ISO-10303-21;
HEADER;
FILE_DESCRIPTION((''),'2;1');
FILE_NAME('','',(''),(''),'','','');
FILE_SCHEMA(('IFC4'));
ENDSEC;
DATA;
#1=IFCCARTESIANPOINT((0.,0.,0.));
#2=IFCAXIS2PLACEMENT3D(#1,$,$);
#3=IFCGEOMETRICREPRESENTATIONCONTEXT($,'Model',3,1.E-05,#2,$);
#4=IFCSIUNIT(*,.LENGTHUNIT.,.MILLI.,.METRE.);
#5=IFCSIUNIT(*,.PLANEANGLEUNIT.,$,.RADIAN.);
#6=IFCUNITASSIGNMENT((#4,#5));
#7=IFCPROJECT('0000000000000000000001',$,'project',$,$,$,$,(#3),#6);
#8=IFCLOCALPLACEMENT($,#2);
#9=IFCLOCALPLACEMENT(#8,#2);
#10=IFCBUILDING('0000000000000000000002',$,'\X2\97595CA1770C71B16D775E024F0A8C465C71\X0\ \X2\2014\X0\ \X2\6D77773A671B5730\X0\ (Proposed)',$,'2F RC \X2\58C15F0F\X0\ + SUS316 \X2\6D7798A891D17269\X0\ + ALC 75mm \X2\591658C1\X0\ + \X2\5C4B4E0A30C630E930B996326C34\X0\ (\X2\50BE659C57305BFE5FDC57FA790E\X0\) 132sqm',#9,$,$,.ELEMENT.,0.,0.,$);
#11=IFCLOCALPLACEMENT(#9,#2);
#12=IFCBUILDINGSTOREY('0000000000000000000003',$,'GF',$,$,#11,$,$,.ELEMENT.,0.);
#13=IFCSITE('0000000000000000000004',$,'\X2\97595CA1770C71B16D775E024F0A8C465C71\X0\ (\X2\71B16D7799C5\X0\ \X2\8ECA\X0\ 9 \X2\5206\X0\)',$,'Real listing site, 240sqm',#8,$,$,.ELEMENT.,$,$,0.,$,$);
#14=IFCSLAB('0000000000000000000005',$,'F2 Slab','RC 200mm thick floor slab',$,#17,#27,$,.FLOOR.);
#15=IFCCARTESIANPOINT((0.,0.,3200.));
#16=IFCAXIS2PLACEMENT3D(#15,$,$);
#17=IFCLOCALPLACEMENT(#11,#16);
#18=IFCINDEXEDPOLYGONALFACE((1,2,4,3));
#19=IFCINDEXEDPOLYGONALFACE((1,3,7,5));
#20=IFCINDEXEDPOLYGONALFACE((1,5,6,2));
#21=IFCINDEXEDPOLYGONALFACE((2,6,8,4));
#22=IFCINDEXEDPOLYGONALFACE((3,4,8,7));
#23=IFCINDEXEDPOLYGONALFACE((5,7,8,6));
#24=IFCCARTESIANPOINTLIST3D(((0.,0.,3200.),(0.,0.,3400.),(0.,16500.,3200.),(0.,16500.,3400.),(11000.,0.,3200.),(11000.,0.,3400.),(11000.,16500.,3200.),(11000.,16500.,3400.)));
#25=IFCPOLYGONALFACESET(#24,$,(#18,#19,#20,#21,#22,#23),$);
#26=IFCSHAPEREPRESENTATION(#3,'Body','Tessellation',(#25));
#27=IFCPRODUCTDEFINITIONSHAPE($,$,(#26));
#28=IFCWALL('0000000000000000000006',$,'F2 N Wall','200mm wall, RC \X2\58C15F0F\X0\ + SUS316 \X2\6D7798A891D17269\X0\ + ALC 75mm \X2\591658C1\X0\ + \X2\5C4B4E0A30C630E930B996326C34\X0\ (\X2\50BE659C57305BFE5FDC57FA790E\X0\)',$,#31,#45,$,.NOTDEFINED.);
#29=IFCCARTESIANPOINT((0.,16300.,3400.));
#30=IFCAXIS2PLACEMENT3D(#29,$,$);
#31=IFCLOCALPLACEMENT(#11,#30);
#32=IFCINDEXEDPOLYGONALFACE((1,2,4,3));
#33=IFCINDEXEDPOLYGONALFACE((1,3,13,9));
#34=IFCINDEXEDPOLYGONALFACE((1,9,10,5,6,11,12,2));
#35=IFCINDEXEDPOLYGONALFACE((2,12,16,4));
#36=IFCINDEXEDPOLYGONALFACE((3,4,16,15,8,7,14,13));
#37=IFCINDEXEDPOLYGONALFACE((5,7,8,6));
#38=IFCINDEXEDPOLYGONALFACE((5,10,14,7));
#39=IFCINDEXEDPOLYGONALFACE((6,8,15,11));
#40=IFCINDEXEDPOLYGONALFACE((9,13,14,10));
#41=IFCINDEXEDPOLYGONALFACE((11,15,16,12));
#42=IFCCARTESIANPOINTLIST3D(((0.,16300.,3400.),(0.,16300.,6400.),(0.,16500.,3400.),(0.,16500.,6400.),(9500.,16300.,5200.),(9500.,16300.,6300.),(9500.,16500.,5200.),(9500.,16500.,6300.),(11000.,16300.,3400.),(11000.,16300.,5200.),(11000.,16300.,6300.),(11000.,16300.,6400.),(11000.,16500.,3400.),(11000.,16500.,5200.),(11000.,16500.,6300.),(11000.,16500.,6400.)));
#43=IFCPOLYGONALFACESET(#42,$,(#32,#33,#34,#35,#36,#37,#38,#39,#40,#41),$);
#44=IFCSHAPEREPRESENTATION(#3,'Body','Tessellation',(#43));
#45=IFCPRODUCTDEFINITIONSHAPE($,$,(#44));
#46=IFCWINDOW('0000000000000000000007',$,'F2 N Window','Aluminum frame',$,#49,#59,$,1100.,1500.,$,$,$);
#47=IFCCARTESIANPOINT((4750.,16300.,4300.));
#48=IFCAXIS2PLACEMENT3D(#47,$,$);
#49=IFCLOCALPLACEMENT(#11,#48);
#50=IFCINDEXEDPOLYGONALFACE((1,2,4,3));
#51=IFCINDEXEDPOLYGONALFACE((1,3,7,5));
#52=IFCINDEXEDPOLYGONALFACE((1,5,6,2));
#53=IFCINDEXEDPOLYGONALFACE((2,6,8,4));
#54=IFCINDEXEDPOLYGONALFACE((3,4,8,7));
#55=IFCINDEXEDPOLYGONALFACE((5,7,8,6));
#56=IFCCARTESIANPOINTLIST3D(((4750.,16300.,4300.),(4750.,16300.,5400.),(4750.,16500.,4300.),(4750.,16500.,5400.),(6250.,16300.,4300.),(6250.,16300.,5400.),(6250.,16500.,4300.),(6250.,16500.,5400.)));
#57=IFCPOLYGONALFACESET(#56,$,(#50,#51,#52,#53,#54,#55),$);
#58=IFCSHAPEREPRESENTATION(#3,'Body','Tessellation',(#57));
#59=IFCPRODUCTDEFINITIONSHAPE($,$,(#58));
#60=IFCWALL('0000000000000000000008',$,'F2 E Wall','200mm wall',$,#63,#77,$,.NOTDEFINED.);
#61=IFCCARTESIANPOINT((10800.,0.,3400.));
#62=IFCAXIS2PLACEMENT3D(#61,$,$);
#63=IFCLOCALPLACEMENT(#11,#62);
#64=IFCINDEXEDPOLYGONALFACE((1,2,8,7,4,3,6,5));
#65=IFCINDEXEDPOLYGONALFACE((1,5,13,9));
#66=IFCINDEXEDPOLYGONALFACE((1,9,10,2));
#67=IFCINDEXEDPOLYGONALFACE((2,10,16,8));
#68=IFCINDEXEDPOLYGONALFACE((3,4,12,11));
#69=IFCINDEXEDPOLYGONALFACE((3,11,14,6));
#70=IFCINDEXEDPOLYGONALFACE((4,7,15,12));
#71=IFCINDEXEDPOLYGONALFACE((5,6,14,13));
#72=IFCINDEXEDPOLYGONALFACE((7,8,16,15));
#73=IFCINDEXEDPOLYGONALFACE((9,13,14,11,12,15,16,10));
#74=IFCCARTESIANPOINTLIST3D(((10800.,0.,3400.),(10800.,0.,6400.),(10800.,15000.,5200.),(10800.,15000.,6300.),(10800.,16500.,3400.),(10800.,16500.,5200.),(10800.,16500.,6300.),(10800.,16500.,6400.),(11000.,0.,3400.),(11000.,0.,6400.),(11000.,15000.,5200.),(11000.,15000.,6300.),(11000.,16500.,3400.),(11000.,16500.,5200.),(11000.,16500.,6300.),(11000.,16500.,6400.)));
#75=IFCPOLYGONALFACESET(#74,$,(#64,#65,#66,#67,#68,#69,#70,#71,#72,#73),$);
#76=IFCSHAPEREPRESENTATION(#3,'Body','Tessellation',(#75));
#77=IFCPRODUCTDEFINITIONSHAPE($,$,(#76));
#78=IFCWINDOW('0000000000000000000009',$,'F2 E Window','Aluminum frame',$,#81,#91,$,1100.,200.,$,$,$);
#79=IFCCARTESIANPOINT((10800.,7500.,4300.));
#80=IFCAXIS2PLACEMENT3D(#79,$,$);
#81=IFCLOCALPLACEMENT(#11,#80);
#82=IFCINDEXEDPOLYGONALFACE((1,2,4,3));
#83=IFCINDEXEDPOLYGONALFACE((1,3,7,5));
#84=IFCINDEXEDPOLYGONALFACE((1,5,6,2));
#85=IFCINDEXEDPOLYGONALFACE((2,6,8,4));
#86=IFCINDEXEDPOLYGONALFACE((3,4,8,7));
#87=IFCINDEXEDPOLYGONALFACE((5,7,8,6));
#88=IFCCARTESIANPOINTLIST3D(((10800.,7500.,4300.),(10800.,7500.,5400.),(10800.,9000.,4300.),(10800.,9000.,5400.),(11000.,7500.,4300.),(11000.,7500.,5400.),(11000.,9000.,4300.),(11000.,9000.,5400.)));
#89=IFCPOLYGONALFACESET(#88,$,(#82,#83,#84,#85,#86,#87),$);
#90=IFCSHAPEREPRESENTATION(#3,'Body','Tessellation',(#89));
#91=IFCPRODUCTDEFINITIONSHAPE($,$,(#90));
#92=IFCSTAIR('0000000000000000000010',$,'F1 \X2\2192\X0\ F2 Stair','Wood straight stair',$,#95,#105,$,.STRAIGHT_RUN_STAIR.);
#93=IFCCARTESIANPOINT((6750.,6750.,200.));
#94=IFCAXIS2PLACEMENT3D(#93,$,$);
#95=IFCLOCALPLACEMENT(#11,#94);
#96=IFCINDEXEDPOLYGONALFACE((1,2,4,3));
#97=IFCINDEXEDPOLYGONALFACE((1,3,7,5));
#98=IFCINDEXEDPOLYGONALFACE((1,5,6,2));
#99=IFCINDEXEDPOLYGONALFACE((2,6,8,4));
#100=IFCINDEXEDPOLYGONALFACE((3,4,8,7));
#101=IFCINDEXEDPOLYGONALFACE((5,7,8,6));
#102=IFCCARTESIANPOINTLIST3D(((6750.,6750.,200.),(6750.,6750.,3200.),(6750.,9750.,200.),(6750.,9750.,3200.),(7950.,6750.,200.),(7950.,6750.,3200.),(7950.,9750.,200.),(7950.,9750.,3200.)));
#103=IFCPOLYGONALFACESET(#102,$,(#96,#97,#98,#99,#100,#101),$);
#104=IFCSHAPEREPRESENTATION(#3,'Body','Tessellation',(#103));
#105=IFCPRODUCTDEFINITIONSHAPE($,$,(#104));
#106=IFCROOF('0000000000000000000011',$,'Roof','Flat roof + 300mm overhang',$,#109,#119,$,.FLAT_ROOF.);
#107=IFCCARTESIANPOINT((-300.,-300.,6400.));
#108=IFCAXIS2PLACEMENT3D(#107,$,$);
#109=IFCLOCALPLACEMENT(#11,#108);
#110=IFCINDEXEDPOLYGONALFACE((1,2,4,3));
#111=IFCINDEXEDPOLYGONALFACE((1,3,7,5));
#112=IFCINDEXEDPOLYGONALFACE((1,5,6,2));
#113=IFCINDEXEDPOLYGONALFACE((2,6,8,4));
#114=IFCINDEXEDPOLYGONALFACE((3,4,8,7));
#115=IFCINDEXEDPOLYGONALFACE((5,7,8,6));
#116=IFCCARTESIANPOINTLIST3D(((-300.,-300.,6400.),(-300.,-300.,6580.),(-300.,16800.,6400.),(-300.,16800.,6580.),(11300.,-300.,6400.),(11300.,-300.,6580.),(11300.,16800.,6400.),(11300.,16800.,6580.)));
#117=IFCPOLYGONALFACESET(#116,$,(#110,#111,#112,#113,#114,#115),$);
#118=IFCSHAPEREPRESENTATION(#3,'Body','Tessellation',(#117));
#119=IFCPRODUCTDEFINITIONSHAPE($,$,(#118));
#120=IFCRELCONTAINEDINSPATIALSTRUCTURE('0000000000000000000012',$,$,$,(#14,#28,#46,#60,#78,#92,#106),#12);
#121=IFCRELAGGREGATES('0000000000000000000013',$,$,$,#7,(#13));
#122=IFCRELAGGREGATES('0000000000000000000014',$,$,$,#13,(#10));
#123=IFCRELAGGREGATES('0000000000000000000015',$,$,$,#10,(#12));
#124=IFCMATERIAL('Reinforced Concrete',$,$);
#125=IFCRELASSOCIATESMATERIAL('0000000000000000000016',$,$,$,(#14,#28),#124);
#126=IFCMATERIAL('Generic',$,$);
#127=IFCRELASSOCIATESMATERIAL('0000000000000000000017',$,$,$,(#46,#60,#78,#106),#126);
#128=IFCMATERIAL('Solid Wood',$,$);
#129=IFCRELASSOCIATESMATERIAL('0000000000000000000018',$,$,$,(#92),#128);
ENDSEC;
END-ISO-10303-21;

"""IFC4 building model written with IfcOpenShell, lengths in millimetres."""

from ifc_helpers import new_model, si_unit, frame, frame_2d, origin, place, context, project, spatial, rectangle, extrude, material, element, fill, save


model = new_model("IFC4")

# Units and contexts
model_context = context("Model", 3, precision=1e-05, world=origin())
ifc_project = project(units=[si_unit("LENGTHUNIT", "METRE", prefix="MILLI"), si_unit("PLANEANGLEUNIT", "RADIAN")], contexts=[model_context])

# Site, building, storey
site_placement = place(None, origin())
site = spatial("IfcSite", under=ifc_project, at=site_placement, Name="静岡県熱海市伊豆山 (熱海駅 車 9 分)", ObjectType="Real listing site, 240sqm", CompositionType="ELEMENT", RefElevation=0.0)
building_placement = place(site_placement, origin())
building = spatial("IfcBuilding", under=site, at=building_placement, Name="静岡県熱海市伊豆山 — 海眺望地 (Proposed)", ObjectType="2F RC 壁式 + SUS316 海風金物 + ALC 75mm 外壁 + 屋上テラス防水 (傾斜地対応基礎) 132sqm", CompositionType="ELEMENT", ElevationOfRefHeight=0.0, ElevationOfTerrain=0.0)
storey_placement = place(building_placement, origin())
storey = spatial("IfcBuildingStorey", under=building, at=storey_placement, Name="GF", CompositionType="ELEMENT", Elevation=0.0)

# Slab
ifc_material_1 = material(Name="Reinforced Concrete")
slab_1_placement = place(storey_placement, frame((0.0, 0.0, 3200.0)))
element("IfcSlab", 1, at=slab_1_placement, inside=storey, material=ifc_material_1, Name="F2 Slab", Description="RC 200mm thick floor slab", PredefinedType="FLOOR", context=model_context, shape_type="SweptSolid", body=[
    extrude(rectangle(XDim=11000.0, YDim=16500.0, at=frame_2d((5500.0, 8250.0))), frame((0.0, 0.0, 3200.0)), (0.0, 0.0, 1.0), 200.0),
])

# Shared definitions
ifc_material_2 = material(Name="Generic")

# Shared definitions
ifc_material_3 = material(Name="Solid Wood")

# Walls, openings, windows
wall_1_placement = place(storey_placement, frame((0.0, 16300.0, 3400.0)))
wall_1 = element("IfcWall", 2, at=wall_1_placement, inside=storey, material=ifc_material_1, Name="F2 N Wall", Description="200mm wall, RC 壁式 + SUS316 海風金物 + ALC 75mm 外壁 + 屋上テラス防水 (傾斜地対応基礎)", PredefinedType="NOTDEFINED", context=model_context, shape_type="SweptSolid", body=[
    extrude(rectangle(XDim=11000.0, YDim=200.0, at=frame_2d((5500.0, 100.0))), frame((0.0, 16300.0, 3400.0)), (0.0, 0.0, 1.0), 3000.0),
])
opening_1_placement = place(storey_placement, frame((4750.0, 16300.0, 4300.0)))
opening_1 = element("IfcOpeningElement", 3, at=opening_1_placement, cuts=wall_1, PredefinedType="NOTDEFINED", context=model_context, shape_type="SweptSolid", body=[
    extrude(rectangle(XDim=1500.0, YDim=200.0, at=frame_2d((750.0, 100.0))), frame((4750.0, 16300.0, 4300.0)), (0.0, 0.0, 1.0), 1100.0),
])
window_1_placement = place(storey_placement, frame((4750.0, 16300.0, 4300.0)))
window_1 = element("IfcWindow", 4, at=window_1_placement, inside=storey, material=ifc_material_2, Name="F2 N Window", Description="Aluminum frame", OverallHeight=1100.0, OverallWidth=1500.0, context=model_context, shape_type="SweptSolid", body=[
    extrude(rectangle(XDim=1500.0, YDim=200.0, at=frame_2d((750.0, 100.0))), frame((4750.0, 16300.0, 4300.0)), (0.0, 0.0, 1.0), 1100.0),
])
fill(opening_1, window_1)
wall_2_placement = place(storey_placement, frame((10800.0, 0.0, 3400.0)))
wall_2 = element("IfcWall", 5, at=wall_2_placement, inside=storey, material=ifc_material_2, Name="F2 E Wall", Description="200mm wall", PredefinedType="NOTDEFINED", context=model_context, shape_type="SweptSolid", body=[
    extrude(rectangle(XDim=200.0, YDim=16500.0, at=frame_2d((100.0, 8250.0))), frame((10800.0, 0.0, 3400.0)), (0.0, 0.0, 1.0), 3000.0),
])
opening_2_placement = place(storey_placement, frame((10800.0, 7500.0, 4300.0)))
opening_2 = element("IfcOpeningElement", 6, at=opening_2_placement, cuts=wall_2, PredefinedType="NOTDEFINED", context=model_context, shape_type="SweptSolid", body=[
    extrude(rectangle(XDim=200.0, YDim=1500.0, at=frame_2d((100.0, 750.0))), frame((10800.0, 7500.0, 4300.0)), (0.0, 0.0, 1.0), 1100.0),
])
window_2_placement = place(storey_placement, frame((10800.0, 7500.0, 4300.0)))
window_2 = element("IfcWindow", 7, at=window_2_placement, inside=storey, material=ifc_material_2, Name="F2 E Window", Description="Aluminum frame", OverallHeight=1100.0, OverallWidth=200.0, context=model_context, shape_type="SweptSolid", body=[
    extrude(rectangle(XDim=200.0, YDim=1500.0, at=frame_2d((100.0, 750.0))), frame((10800.0, 7500.0, 4300.0)), (0.0, 0.0, 1.0), 1100.0),
])
fill(opening_2, window_2)

# Stair
stair_placement = place(storey_placement, frame((6750.0, 6750.0, 200.0)))
element("IfcStair", 8, at=stair_placement, inside=storey, material=ifc_material_3, Name="F1 → F2 Stair", Description="Wood straight stair", PredefinedType="STRAIGHT_RUN_STAIR", context=model_context, shape_type="SweptSolid", body=[
    extrude(rectangle(XDim=1200.0, YDim=3000.0, at=frame_2d((600.0, 1500.0))), frame((6750.0, 6750.0, 200.0)), (0.0, 0.0, 1.0), 3000.0),
])

# Roof
roof_placement = place(storey_placement, frame((-300.0, -300.0, 6400.0)))
element("IfcRoof", 9, at=roof_placement, inside=storey, material=ifc_material_2, Name="Roof", Description="Flat roof + 300mm overhang", PredefinedType="FLAT_ROOF", context=model_context, shape_type="SweptSolid", body=[
    extrude(rectangle(XDim=11600.0, YDim=17100.0, at=frame_2d((5800.0, 8550.0))), frame((-300.0, -300.0, 6400.0)), (0.0, 0.0, 1.0), 180.0),
])

save(model, "model.ifc")
